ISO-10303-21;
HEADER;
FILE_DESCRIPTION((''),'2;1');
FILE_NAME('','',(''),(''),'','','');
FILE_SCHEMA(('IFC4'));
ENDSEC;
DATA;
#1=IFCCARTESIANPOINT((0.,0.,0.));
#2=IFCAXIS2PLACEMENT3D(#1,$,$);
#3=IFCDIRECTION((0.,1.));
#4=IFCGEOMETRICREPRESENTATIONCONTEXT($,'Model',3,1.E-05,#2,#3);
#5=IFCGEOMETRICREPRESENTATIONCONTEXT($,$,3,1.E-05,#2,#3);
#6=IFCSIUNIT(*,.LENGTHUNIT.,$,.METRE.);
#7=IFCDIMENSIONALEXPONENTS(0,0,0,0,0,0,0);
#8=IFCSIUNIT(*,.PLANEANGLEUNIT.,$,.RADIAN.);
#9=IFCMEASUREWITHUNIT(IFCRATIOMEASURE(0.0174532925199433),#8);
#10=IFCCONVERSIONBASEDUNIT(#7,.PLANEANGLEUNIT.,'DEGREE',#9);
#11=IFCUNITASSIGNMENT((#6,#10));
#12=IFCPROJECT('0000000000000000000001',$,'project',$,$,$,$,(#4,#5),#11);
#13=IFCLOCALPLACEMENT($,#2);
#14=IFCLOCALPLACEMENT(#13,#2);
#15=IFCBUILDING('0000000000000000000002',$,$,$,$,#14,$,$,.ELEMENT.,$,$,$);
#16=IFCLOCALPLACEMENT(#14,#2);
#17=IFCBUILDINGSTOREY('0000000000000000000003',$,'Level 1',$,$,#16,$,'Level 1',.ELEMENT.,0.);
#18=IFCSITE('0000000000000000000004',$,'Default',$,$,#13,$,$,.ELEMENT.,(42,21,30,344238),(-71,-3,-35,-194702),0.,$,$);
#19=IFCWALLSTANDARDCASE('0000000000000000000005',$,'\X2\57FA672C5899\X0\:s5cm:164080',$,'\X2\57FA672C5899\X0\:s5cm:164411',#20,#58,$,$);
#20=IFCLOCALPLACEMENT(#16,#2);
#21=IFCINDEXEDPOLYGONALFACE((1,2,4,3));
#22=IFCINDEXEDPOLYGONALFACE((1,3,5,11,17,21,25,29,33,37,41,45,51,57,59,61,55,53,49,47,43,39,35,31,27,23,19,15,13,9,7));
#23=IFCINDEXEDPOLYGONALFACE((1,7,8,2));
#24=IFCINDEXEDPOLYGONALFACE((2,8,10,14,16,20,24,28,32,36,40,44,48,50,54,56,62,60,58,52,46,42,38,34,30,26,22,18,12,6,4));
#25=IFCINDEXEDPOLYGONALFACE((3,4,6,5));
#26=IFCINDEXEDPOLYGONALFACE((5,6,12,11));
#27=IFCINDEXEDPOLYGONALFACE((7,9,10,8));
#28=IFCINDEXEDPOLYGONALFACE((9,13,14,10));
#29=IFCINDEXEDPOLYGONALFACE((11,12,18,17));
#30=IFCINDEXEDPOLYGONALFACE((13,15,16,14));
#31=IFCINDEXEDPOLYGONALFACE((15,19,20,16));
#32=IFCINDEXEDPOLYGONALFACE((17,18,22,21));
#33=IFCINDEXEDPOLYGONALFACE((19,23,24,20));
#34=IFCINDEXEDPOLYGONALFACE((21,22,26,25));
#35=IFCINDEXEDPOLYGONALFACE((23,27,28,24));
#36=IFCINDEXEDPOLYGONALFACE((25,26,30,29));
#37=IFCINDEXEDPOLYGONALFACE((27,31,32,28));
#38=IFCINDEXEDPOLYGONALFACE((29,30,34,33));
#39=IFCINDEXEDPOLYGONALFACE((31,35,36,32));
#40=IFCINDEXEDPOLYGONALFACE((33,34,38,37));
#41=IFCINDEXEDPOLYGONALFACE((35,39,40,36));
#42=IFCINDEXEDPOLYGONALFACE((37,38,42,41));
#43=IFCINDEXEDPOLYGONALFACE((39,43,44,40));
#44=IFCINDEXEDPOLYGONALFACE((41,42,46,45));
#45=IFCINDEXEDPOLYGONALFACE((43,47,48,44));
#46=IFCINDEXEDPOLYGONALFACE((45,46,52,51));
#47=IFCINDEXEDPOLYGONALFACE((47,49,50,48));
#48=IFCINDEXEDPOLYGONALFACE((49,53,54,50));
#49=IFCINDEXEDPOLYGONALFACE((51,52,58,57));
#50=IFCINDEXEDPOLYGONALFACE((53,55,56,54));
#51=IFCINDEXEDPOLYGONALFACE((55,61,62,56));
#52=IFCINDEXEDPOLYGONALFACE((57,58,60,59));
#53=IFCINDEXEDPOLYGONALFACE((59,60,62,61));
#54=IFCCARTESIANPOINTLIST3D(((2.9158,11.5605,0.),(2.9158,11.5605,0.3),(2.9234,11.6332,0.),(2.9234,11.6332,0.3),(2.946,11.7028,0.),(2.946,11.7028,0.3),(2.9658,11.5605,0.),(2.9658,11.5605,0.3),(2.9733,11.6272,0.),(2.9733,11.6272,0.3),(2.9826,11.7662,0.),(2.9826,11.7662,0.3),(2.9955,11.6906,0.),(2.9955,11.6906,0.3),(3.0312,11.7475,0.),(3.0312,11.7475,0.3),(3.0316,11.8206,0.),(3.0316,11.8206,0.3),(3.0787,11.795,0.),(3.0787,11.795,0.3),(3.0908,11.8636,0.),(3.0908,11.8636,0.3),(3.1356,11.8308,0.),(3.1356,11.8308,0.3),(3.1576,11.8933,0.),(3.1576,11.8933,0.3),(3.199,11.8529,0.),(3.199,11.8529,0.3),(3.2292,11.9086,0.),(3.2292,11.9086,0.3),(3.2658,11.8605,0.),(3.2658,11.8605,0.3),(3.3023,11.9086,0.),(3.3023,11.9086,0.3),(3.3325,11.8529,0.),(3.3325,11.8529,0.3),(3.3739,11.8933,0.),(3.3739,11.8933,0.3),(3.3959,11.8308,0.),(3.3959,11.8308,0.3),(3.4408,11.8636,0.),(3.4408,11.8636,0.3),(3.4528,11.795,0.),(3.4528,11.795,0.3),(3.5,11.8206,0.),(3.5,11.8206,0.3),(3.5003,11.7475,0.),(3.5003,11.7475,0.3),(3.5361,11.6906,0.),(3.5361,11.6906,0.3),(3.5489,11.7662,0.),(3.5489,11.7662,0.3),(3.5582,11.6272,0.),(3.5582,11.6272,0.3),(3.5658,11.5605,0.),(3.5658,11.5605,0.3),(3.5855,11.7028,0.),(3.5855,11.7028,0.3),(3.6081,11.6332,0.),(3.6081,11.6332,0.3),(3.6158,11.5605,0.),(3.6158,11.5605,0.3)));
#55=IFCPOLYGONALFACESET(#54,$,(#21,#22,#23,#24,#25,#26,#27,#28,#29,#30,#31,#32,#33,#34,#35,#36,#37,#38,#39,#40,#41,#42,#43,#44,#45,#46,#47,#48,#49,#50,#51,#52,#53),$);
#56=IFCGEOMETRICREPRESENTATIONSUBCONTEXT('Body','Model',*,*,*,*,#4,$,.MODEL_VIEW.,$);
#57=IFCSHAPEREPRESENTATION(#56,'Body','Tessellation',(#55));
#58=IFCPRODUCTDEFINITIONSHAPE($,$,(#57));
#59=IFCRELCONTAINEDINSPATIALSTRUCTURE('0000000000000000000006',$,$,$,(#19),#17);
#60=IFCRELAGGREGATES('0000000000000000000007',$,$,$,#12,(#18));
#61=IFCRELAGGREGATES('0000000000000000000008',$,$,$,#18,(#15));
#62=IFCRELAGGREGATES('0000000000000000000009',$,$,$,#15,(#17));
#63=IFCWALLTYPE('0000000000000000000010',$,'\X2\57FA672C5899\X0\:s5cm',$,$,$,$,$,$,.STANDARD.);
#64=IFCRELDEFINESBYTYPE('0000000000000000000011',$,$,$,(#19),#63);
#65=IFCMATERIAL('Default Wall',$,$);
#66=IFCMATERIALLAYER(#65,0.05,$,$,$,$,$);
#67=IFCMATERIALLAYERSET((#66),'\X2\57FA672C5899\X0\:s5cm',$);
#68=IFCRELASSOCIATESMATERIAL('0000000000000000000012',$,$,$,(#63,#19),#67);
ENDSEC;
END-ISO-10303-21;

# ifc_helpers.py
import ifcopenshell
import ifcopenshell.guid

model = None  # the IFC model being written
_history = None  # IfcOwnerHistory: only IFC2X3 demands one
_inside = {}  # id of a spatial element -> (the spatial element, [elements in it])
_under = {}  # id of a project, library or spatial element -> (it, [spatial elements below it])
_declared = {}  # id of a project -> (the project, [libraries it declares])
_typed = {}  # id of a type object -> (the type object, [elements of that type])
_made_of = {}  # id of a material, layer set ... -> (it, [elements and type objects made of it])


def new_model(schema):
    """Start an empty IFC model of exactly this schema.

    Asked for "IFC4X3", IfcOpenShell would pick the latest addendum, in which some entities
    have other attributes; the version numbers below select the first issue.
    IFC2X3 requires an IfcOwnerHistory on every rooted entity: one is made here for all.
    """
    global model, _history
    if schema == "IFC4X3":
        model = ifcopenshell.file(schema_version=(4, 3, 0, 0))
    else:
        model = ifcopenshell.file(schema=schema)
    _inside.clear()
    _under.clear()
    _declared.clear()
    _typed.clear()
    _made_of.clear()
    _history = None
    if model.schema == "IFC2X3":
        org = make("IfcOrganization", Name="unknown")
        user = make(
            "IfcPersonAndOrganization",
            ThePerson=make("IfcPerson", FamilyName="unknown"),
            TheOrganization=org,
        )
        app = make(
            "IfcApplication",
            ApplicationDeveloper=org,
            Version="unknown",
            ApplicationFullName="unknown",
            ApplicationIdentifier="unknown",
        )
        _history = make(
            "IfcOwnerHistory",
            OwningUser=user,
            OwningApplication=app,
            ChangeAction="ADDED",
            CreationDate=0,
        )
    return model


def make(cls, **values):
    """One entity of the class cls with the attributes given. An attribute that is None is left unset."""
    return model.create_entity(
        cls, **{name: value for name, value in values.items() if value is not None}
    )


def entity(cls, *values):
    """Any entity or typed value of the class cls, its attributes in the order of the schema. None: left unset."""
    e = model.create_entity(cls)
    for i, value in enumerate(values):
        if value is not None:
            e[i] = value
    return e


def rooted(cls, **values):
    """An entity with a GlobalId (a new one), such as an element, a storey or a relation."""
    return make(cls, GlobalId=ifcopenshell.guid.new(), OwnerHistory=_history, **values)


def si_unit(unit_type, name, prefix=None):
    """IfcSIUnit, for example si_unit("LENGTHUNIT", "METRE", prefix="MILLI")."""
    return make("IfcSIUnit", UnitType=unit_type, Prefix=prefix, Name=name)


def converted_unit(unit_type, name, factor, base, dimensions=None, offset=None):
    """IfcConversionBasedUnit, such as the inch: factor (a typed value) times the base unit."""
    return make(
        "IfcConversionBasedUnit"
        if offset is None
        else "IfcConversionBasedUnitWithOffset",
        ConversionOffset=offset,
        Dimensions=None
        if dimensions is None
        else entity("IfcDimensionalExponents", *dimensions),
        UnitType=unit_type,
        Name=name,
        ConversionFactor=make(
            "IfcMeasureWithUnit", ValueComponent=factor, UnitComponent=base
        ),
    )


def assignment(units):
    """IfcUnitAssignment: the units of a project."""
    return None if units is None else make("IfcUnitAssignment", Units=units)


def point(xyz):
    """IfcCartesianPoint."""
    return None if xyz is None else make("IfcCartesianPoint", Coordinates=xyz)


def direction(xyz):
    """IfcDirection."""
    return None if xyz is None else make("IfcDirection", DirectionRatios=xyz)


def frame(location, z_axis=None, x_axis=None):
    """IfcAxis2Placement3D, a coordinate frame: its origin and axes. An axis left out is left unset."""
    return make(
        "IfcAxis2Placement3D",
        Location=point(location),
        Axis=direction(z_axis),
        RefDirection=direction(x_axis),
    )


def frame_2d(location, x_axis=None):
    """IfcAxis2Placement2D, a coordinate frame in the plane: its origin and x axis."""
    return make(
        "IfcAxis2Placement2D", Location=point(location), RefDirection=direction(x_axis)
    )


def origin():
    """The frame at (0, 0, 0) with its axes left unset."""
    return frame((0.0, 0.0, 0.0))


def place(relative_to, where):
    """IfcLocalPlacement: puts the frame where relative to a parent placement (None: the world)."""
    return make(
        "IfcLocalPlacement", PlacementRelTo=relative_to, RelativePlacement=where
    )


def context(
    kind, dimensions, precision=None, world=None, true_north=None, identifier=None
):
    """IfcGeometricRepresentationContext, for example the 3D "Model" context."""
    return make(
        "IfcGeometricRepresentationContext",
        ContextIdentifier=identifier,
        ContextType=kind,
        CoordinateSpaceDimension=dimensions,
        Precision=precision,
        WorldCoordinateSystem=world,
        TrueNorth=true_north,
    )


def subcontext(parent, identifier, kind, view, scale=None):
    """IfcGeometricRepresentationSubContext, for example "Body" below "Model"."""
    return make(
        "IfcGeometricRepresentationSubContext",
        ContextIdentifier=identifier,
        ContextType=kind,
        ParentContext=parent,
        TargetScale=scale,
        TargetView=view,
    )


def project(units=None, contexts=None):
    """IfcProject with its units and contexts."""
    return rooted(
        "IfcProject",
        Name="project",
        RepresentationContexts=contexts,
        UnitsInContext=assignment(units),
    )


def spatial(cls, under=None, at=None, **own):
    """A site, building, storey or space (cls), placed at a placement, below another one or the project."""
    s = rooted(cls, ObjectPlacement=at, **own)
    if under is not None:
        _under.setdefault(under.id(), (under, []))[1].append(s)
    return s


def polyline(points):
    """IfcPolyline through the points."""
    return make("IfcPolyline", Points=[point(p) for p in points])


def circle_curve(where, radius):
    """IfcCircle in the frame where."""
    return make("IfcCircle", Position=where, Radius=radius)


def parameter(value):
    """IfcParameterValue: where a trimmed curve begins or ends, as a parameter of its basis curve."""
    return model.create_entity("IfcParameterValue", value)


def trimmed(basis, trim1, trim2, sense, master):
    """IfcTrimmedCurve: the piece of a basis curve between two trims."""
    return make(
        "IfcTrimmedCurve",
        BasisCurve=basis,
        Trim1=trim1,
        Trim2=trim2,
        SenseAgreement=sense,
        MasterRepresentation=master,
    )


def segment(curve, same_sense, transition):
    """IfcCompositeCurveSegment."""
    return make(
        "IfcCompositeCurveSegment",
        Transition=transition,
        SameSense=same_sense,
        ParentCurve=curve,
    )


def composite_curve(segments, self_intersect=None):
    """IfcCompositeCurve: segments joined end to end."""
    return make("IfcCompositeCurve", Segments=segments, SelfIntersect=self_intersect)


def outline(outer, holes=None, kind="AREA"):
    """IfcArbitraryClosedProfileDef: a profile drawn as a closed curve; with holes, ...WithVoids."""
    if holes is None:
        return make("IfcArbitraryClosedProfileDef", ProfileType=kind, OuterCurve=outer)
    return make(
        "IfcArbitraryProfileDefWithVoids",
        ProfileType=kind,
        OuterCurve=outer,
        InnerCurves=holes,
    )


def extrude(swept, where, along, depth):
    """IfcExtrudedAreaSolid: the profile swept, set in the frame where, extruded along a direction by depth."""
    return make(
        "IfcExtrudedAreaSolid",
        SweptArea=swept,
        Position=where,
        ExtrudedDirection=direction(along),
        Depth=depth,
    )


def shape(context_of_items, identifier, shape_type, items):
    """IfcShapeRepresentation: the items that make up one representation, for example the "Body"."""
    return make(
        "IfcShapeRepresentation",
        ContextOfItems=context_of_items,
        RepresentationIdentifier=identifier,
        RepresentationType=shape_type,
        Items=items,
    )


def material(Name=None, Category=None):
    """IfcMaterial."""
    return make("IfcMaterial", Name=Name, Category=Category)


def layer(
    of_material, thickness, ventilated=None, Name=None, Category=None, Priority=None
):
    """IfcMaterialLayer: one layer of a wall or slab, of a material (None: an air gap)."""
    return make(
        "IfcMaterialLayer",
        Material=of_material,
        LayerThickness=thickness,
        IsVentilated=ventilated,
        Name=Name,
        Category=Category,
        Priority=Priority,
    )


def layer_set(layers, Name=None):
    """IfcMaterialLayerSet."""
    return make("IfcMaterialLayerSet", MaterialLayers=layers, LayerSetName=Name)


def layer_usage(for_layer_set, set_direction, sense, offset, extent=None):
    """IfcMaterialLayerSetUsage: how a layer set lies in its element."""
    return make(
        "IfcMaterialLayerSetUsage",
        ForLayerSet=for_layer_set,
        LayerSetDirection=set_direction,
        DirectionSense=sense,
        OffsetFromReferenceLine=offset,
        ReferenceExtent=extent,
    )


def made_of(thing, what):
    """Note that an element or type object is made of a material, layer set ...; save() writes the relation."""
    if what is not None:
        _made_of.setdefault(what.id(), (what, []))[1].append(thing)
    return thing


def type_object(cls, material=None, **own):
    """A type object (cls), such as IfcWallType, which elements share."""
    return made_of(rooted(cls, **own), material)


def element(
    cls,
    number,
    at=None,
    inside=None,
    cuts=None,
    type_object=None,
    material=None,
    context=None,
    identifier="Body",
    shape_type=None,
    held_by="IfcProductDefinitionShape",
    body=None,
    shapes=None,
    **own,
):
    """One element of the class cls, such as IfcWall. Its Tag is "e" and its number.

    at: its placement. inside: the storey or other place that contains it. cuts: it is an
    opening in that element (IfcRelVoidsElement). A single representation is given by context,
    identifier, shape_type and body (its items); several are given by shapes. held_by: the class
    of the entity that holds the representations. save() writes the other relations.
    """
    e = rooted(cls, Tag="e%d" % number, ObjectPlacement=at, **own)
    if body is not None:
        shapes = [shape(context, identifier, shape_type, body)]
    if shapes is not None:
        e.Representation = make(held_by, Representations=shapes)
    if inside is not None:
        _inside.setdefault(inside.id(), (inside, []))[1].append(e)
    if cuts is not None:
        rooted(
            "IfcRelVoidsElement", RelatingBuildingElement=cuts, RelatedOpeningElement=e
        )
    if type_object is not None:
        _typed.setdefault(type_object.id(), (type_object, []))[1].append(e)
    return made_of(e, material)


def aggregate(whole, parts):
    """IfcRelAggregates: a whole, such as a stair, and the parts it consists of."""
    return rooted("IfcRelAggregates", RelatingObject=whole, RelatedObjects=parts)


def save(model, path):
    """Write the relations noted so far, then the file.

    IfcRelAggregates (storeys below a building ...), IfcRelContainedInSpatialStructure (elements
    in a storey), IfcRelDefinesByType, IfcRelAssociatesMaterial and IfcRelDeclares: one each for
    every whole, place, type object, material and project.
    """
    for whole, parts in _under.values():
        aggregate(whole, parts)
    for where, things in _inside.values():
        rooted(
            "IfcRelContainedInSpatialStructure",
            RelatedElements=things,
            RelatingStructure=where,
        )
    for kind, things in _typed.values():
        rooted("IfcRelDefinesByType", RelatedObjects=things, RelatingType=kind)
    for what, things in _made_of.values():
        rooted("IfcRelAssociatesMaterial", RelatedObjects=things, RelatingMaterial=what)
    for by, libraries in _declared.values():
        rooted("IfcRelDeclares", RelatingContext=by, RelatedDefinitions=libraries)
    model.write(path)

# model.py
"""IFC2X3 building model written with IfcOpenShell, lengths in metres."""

from ifc_helpers import new_model, entity, si_unit, converted_unit, direction, frame, frame_2d, origin, place, context, subcontext, project, spatial, polyline, circle_curve, parameter, trimmed, segment, composite_curve, outline, extrude, material, layer, layer_set, layer_usage, type_object, element, save


model = new_model("IFC2X3")

# Units and contexts
model_context = context("Model", 3, precision=1e-05, world=origin(), true_north=direction((0.0, 1.0)))
context_of_model = context(None, 3, precision=1e-05, world=origin(), true_north=direction((0.0, 1.0)))
body_context = subcontext(model_context, "Body", "Model", "MODEL_VIEW")
ifc_project = project(units=[si_unit("LENGTHUNIT", "METRE"), converted_unit("PLANEANGLEUNIT", "DEGREE", entity("IfcRatioMeasure", 0.0174532925199433), si_unit("PLANEANGLEUNIT", "RADIAN"), dimensions=[0, 0, 0, 0, 0, 0, 0])], contexts=[model_context, context_of_model])

# Site, building, storey
site_placement = place(None, origin())
site = spatial("IfcSite", under=ifc_project, at=site_placement, Name="Default", CompositionType="ELEMENT", RefLatitude=(42, 21, 30, 344238), RefLongitude=(-71, -3, -35, -194702), RefElevation=0.0)
building_placement = place(site_placement, origin())
building = spatial("IfcBuilding", under=site, at=building_placement, CompositionType="ELEMENT")
storey_placement = place(building_placement, origin())
storey = spatial("IfcBuildingStorey", under=building, at=storey_placement, Name="Level 1", LongName="Level 1", CompositionType="ELEMENT", Elevation=0.0)

# Shared definitions
ifc_material_1 = material(Name="Default Wall")

# Wall
ifc_layer_1 = layer(ifc_material_1, 0.05)
ifc_layer_set_1 = layer_set([ifc_layer_1], Name="基本墙:s5cm")
wall_type_1 = type_object("IfcWallType", Name="基本墙:s5cm", PredefinedType="STANDARD", material=ifc_layer_set_1)
ifc_layer_usage_1 = layer_usage(ifc_layer_set_1, "AXIS2", "POSITIVE", -0.025)
wall_1_placement = place(storey_placement, frame((2.9408, 11.5605, 0.0)))
element("IfcWallStandardCase", 1, at=wall_1_placement, inside=storey, type_object=wall_type_1, material=ifc_layer_usage_1, Name="基本墙:s5cm:164080", ObjectType="基本墙:s5cm:164411", context=body_context, shape_type="SweptSolid", body=[
    extrude(outline(composite_curve([segment(trimmed(circle_curve(frame_2d((0.325, 0.0), x_axis=(1.0, 0.0)), 0.35), [parameter(0.0)], [parameter(180.0)], True, "PARAMETER"), True, "CONTINUOUS"), segment(polyline([(-0.025, 0.0), (0.025, 0.0)]), True, "CONTINUOUS"), segment(trimmed(circle_curve(frame_2d((0.325, 0.0), x_axis=(1.0, 0.0)), 0.3), [parameter(0.0)], [parameter(180.0)], True, "PARAMETER"), False, "CONTINUOUS"), segment(polyline([(0.625, 0.0), (0.675, 0.0)]), True, "CONTINUOUS")], self_intersect=False)), origin(), (0.0, 0.0, 1.0), 0.3),
])

save(model, "model.ifc")
